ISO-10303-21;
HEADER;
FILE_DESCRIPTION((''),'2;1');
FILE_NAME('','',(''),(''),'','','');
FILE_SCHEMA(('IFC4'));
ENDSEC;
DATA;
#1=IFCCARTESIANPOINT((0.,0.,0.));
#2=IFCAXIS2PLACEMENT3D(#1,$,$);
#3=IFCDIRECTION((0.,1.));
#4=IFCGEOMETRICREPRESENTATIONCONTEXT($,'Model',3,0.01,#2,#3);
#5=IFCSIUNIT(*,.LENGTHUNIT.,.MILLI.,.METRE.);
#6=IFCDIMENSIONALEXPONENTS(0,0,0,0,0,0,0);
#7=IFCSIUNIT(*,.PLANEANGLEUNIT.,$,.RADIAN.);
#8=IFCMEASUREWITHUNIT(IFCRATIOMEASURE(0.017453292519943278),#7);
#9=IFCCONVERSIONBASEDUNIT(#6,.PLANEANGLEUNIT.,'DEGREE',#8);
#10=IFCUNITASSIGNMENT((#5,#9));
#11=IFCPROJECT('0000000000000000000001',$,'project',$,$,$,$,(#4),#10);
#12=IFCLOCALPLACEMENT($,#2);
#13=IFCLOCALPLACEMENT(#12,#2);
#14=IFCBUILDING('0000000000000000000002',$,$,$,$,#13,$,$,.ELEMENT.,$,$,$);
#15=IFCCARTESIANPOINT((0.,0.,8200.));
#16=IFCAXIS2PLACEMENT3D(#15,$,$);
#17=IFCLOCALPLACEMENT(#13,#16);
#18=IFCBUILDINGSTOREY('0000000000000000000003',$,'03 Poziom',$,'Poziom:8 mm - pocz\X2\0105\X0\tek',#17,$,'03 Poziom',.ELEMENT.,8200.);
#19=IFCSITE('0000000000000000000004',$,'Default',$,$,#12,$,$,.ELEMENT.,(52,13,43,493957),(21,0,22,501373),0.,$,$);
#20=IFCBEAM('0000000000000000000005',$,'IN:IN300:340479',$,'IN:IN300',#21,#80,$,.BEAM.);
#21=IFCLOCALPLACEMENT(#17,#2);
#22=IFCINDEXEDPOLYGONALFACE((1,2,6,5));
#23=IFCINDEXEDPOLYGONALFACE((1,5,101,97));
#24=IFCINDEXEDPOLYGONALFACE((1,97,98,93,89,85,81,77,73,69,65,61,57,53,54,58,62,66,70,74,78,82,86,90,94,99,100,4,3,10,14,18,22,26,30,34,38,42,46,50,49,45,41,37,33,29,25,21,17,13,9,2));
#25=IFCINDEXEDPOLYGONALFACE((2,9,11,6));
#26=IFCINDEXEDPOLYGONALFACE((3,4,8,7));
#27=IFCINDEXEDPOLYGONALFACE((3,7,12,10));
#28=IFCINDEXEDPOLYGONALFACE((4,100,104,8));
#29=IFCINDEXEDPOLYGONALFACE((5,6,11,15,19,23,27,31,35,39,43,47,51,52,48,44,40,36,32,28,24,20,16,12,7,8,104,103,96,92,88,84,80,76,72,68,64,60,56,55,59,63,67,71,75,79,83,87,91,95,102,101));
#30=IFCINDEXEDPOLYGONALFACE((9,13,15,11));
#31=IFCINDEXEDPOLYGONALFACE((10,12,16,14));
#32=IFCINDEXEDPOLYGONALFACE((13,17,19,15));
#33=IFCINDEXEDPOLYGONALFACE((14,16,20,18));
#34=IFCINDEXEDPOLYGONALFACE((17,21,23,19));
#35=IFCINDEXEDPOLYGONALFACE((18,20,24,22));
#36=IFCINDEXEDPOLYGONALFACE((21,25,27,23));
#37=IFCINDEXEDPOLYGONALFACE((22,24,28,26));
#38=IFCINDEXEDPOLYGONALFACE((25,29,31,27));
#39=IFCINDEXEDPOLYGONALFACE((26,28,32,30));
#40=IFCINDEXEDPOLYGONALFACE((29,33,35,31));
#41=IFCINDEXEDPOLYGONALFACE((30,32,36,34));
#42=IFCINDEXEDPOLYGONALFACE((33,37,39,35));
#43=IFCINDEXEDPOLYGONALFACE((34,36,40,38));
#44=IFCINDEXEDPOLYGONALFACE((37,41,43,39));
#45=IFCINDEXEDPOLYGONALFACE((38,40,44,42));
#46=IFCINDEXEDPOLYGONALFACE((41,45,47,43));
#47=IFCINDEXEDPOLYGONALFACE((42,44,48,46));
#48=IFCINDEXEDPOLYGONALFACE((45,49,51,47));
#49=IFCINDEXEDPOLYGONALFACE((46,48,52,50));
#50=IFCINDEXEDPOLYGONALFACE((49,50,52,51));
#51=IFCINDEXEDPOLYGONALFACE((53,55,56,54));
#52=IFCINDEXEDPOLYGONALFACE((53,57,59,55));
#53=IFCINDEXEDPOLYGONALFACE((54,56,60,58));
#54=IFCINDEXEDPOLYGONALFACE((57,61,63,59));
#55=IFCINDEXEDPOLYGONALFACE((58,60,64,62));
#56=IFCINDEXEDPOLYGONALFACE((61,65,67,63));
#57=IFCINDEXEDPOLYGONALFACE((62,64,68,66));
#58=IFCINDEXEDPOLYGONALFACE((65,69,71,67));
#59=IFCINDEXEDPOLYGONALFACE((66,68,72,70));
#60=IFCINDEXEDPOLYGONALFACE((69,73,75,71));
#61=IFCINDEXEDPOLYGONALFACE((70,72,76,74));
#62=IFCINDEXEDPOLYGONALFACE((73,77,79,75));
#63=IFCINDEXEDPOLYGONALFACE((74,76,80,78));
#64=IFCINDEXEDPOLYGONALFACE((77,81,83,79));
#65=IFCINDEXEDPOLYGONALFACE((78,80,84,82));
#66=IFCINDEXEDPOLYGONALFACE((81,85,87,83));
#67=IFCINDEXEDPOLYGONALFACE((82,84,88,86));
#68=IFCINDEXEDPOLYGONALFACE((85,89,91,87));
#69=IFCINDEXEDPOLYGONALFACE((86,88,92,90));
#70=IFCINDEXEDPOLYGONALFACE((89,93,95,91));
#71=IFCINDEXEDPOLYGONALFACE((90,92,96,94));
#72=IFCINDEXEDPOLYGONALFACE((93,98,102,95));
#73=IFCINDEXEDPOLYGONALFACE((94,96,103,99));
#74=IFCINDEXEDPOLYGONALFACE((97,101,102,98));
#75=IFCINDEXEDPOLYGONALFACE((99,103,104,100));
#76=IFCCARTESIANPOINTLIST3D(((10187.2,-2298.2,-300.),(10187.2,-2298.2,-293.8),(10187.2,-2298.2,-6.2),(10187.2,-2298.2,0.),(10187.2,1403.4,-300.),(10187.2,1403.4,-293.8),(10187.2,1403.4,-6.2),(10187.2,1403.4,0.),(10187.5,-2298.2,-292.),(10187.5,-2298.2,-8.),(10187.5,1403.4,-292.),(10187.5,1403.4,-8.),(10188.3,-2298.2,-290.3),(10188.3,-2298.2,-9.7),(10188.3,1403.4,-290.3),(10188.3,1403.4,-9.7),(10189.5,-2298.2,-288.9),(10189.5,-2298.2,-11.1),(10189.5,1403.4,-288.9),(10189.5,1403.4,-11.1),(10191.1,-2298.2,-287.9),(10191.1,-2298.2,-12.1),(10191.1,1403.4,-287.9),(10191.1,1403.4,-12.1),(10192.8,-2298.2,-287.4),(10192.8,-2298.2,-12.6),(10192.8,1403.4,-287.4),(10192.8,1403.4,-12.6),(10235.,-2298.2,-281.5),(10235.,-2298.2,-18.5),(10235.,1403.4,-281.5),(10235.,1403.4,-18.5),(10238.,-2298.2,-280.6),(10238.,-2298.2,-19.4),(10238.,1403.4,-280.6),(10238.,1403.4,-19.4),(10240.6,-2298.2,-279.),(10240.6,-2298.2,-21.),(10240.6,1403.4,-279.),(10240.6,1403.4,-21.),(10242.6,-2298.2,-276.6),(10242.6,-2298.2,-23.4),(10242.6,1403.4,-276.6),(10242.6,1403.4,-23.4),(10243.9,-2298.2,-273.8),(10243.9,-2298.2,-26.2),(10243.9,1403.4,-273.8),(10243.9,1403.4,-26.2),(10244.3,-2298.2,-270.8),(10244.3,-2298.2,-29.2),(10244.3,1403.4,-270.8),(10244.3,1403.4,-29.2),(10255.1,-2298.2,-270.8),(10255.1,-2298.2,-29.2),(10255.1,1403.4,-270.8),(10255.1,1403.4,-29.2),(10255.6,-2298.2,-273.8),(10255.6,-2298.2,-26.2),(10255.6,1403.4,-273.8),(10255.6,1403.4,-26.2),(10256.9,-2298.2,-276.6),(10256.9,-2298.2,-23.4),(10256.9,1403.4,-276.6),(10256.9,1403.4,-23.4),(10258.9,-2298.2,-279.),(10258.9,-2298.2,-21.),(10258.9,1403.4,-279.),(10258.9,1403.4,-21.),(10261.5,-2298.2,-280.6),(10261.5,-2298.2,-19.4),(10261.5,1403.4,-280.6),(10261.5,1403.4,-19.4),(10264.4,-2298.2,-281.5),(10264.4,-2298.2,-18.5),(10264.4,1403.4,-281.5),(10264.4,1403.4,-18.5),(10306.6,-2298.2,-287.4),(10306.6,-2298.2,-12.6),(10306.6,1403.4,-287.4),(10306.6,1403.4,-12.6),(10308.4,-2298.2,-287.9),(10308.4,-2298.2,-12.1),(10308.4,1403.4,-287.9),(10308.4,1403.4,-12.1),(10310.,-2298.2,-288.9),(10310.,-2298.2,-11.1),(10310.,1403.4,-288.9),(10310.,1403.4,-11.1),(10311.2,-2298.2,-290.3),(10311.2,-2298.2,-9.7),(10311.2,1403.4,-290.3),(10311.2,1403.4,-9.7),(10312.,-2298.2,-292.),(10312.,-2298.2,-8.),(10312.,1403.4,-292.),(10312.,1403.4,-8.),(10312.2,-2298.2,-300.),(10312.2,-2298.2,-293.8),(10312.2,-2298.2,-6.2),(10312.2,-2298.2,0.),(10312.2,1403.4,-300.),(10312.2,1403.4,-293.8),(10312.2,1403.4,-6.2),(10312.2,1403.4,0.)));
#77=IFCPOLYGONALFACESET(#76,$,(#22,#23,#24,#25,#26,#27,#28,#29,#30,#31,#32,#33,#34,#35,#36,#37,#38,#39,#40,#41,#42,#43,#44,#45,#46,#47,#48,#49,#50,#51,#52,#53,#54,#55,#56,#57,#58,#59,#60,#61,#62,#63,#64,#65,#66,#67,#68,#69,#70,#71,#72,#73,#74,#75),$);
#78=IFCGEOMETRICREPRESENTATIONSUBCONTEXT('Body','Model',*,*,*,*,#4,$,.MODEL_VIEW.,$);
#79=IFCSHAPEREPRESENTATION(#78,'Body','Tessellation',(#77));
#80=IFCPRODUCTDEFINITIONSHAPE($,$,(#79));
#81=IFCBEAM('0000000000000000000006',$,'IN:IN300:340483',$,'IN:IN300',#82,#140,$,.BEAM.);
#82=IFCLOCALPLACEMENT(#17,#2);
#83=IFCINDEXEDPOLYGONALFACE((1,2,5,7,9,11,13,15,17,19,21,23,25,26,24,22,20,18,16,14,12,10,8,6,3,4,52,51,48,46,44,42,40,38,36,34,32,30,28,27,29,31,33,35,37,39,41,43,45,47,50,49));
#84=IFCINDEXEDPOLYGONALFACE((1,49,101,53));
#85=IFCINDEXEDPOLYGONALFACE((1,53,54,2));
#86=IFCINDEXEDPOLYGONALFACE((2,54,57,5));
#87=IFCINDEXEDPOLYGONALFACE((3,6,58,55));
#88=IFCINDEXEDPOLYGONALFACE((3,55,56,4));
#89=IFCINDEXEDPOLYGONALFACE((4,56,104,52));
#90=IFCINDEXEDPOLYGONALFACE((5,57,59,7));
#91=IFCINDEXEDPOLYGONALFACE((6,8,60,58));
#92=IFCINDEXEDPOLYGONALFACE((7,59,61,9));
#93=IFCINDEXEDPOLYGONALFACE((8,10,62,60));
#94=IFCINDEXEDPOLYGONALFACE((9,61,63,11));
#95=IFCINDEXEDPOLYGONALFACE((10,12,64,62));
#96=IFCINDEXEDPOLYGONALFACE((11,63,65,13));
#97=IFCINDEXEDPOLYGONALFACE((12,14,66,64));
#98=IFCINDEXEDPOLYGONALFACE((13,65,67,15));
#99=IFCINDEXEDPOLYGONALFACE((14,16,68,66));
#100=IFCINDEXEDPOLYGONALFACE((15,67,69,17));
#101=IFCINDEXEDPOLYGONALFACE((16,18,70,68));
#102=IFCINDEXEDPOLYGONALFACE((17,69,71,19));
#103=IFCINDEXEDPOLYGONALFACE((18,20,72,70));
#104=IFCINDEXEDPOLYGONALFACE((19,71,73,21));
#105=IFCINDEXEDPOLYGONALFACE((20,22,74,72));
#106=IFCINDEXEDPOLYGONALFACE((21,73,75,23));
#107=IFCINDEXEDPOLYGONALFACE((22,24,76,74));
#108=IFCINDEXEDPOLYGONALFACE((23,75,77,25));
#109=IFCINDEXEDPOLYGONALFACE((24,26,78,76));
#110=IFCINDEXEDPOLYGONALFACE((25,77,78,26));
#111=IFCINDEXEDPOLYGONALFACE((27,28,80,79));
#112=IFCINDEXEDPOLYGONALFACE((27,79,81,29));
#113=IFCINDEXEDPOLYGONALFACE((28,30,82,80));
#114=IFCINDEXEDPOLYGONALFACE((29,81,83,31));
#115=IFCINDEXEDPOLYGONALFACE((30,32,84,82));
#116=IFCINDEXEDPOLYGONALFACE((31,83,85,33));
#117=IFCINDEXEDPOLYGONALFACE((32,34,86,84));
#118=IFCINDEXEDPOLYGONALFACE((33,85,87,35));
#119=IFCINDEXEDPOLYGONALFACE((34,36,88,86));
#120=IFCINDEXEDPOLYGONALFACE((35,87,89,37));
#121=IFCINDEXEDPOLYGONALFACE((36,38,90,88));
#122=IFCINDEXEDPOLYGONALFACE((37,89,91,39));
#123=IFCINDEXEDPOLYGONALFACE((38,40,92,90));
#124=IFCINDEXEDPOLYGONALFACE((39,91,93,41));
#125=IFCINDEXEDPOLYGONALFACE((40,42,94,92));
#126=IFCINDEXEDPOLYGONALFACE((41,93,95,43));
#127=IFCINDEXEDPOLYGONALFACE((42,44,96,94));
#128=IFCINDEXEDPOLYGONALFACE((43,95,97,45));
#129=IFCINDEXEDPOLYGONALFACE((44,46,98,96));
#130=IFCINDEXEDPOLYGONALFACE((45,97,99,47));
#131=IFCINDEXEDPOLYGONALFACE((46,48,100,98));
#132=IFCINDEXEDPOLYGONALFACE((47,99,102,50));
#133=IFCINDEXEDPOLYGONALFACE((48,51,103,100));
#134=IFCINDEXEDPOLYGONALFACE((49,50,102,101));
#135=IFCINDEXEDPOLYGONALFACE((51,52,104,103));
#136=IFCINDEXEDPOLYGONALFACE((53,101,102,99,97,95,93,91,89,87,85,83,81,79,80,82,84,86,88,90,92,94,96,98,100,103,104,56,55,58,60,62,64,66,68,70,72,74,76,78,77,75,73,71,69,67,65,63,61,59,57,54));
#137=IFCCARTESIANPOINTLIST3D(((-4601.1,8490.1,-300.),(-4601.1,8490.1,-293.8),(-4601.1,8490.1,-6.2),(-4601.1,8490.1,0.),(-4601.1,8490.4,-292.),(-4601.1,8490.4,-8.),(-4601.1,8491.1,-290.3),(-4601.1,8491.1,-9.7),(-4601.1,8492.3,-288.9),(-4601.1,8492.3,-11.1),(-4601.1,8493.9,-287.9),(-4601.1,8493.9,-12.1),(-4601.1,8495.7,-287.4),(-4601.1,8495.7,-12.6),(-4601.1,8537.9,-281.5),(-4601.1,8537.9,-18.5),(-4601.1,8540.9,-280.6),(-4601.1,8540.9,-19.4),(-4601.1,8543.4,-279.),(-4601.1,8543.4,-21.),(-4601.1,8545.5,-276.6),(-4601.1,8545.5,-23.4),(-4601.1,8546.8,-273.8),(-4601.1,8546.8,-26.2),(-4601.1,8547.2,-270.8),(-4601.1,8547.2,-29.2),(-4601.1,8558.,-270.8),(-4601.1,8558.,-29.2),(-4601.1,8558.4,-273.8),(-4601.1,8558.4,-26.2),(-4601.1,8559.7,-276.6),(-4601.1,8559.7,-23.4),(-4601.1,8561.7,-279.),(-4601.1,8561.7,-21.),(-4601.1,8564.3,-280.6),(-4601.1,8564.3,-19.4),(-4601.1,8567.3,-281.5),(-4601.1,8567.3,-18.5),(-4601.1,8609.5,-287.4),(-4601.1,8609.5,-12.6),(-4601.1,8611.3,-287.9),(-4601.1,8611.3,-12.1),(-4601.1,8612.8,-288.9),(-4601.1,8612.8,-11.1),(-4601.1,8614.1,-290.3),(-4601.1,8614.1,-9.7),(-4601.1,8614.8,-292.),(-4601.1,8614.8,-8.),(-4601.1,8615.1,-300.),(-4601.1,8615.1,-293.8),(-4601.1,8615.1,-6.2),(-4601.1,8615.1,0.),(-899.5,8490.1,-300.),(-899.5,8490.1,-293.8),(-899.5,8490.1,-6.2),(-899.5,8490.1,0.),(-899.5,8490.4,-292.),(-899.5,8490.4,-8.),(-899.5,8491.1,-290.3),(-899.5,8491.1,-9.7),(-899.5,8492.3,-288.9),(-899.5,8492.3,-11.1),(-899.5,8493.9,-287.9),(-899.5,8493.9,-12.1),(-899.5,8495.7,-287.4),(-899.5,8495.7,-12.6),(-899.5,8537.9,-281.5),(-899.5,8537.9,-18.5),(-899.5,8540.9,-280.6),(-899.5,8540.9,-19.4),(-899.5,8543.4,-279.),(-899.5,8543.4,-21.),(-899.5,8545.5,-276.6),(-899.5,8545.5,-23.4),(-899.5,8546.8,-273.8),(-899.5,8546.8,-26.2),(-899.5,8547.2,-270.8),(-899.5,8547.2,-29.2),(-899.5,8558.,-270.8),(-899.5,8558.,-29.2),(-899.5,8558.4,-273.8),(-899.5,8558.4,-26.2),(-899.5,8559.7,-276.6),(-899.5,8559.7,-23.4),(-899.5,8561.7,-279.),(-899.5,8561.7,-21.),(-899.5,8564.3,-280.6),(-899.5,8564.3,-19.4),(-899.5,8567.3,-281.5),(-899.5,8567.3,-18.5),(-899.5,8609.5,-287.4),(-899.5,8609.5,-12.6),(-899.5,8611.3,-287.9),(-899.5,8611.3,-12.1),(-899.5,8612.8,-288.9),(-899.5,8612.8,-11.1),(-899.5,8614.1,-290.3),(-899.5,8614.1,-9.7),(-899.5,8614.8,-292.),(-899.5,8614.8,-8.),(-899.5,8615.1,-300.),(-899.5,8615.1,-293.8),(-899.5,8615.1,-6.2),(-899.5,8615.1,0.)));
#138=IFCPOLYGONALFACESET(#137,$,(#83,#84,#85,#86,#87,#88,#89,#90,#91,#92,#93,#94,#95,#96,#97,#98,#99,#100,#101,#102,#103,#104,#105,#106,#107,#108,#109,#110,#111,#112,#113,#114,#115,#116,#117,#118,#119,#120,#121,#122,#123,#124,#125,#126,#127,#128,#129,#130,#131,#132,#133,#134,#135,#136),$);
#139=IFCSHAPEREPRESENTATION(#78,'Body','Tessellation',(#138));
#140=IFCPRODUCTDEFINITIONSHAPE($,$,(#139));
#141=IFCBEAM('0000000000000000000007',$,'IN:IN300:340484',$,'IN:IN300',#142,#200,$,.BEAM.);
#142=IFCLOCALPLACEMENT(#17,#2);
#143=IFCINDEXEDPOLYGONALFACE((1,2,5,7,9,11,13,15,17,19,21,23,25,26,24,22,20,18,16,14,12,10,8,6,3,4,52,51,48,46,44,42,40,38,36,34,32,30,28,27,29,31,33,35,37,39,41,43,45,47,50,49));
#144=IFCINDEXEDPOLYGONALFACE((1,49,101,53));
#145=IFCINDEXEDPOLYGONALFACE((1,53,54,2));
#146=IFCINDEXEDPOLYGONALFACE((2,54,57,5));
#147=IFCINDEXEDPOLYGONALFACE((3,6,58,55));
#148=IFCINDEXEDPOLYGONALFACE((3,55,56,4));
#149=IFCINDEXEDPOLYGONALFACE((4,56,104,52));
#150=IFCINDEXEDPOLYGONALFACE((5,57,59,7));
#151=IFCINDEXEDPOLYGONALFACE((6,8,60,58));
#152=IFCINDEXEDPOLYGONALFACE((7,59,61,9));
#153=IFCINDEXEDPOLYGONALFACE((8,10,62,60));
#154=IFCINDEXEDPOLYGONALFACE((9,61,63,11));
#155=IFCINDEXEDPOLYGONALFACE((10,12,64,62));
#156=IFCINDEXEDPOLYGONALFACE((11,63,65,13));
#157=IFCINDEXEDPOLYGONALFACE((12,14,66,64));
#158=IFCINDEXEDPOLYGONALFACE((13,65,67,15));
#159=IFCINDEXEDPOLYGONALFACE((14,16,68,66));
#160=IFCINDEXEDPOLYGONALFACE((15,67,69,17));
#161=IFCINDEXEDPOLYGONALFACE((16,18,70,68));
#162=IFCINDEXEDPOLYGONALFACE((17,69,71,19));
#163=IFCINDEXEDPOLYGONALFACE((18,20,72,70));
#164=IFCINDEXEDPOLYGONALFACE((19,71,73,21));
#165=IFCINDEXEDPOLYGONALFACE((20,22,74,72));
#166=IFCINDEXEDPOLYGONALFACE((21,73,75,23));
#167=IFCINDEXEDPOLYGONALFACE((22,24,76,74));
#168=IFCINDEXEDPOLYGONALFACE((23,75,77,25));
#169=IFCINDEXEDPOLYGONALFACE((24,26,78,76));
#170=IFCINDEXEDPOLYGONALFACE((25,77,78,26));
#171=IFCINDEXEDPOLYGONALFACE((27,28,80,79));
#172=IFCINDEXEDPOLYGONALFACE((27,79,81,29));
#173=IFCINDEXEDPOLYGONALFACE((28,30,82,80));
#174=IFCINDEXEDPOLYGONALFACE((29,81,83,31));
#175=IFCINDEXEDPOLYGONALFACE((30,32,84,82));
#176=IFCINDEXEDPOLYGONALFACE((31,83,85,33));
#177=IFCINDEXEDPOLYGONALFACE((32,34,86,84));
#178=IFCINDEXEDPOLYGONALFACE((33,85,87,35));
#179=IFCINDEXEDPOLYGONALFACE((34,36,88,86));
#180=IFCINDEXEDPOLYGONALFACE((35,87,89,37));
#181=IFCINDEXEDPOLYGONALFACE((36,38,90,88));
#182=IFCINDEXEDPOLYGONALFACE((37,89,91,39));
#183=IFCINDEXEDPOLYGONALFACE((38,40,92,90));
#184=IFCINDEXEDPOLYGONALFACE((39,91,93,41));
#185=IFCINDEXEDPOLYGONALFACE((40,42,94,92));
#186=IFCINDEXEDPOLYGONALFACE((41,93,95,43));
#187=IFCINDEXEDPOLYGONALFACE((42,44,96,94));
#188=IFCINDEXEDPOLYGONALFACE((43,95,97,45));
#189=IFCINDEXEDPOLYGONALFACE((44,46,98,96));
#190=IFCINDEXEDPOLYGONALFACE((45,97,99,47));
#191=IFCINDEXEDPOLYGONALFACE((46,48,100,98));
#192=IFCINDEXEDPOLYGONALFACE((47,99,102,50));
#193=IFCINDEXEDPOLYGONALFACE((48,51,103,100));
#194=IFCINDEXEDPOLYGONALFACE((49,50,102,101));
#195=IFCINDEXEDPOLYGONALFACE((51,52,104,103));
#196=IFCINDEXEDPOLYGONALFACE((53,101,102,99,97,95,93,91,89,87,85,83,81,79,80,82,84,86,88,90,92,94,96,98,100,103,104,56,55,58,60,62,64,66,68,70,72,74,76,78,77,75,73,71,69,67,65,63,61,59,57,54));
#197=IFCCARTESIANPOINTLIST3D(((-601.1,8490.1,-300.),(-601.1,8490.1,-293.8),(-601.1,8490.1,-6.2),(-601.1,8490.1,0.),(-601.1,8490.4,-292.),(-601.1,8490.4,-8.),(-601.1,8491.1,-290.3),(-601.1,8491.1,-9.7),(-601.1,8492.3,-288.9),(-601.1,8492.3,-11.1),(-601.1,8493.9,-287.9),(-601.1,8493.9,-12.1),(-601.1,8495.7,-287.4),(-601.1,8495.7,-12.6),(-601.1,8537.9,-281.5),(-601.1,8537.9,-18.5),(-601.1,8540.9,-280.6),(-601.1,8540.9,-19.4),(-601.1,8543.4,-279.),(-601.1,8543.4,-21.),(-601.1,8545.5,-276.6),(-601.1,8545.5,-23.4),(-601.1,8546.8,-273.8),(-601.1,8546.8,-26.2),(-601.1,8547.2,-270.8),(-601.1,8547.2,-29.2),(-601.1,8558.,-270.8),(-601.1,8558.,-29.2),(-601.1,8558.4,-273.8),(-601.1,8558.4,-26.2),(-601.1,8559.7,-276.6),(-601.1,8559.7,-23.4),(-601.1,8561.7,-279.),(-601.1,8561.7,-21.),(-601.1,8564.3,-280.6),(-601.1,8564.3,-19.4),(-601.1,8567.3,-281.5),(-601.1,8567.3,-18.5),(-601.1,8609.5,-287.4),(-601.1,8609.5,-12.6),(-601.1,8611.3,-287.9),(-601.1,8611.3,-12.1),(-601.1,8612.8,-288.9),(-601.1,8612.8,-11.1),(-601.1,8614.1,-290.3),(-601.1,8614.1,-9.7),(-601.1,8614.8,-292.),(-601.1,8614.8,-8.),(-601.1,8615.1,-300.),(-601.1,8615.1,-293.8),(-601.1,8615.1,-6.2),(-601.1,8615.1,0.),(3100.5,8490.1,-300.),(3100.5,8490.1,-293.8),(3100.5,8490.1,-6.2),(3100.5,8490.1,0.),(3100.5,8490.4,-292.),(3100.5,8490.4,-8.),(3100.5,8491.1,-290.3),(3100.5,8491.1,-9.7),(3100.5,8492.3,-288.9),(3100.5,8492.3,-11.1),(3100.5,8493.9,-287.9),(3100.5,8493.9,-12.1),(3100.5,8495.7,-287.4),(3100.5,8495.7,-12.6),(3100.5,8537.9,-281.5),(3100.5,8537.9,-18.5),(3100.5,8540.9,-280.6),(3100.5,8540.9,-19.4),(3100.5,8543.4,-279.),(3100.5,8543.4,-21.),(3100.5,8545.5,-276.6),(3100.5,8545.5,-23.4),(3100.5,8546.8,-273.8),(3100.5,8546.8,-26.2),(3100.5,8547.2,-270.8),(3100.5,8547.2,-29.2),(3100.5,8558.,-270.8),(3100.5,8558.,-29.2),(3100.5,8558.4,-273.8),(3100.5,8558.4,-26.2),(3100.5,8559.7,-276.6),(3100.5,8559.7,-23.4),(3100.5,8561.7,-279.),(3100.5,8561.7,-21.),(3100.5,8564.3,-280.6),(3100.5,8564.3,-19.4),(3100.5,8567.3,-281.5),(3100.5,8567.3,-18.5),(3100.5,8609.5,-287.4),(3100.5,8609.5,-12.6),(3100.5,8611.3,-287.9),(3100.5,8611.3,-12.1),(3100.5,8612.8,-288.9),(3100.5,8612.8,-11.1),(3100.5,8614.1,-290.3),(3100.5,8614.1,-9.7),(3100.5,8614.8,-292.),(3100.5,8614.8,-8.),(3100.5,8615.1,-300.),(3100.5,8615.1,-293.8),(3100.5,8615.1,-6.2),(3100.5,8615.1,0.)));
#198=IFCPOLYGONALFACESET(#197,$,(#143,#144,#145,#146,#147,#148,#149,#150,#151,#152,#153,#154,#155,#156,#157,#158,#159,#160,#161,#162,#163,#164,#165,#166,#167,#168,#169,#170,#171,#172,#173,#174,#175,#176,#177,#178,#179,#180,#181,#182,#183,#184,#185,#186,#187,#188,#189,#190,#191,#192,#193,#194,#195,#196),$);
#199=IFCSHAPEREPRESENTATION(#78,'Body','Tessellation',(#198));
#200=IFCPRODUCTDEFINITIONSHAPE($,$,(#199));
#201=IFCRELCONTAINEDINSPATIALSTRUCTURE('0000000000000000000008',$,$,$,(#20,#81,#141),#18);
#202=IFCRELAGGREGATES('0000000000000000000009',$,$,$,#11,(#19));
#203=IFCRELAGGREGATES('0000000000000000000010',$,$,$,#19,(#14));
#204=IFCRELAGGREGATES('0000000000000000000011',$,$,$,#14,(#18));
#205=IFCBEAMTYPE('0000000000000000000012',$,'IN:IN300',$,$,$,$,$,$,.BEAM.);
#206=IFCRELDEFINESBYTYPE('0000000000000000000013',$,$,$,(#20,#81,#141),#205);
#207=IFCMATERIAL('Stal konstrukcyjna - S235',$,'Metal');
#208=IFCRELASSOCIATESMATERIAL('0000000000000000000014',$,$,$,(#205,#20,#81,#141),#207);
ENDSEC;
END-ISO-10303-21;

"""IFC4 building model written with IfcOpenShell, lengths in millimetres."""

from ifc_helpers import new_model, entity, si_unit, converted_unit, direction, frame, origin, place, context, subcontext, project, spatial, line, arc, indexed_curve, outline, extrude, source, transform, mapped, material, type_object, type_shapes, element, save


model = new_model("IFC4")

# Units and contexts
model_context = context("Model", 3, precision=0.01, world=origin(), true_north=direction((0.0, 1.0)))
body_context = subcontext(model_context, "Body", "Model", "MODEL_VIEW")
ifc_project = project(units=[si_unit("LENGTHUNIT", "METRE", prefix="MILLI"), converted_unit("PLANEANGLEUNIT", "DEGREE", entity("IfcRatioMeasure", 0.017453292519943278), si_unit("PLANEANGLEUNIT", "RADIAN"), dimensions=[0, 0, 0, 0, 0, 0, 0])], contexts=[model_context])

# Site, building, storey
site_placement = place(None, origin())
site = spatial("IfcSite", under=ifc_project, at=site_placement, Name="Default", CompositionType="ELEMENT", RefLatitude=(52, 13, 43, 493957), RefLongitude=(21, 0, 22, 501373), RefElevation=0.0)
building_placement = place(site_placement, origin())
building = spatial("IfcBuilding", under=site, at=building_placement, CompositionType="ELEMENT")
storey_placement = place(building_placement, frame((0.0, 0.0, 8200.0)))
storey = spatial("IfcBuildingStorey", under=building, at=storey_placement, Name="03 Poziom", ObjectType="Poziom:8 mm - początek", LongName="03 Poziom", CompositionType="ELEMENT", Elevation=8200.0)

# Shared definitions
ifc_material_1 = material(Name="Stal konstrukcyjna - S235", Category="Metal")

# Beams
beam_type_1 = type_object("IfcBeamType", Name="IN:IN300", PredefinedType="BEAM", material=ifc_material_1)
shared_shape_1 = source(origin(), body_context, "Body", "SweptSolid", [
    extrude(outline(indexed_curve([(143.8, -62.5), (150.0, -62.5), (150.0, 62.5), (143.8, 62.5), (139.6, 60.9), (137.4, 56.9), (131.5, 14.7), (127.9, 8.1), (120.8, 5.4), (-120.8, 5.4), (-127.9, 8.1), (-131.5, 14.7), (-137.4, 56.9), (-139.6, 60.9), (-143.8, 62.5), (-150.0, 62.5), (-150.0, -62.5), (-143.8, -62.5), (-139.6, -60.9), (-137.4, -56.9), (-131.5, -14.7), (-127.9, -8.1), (-120.8, -5.4), (120.8, -5.4), (127.9, -8.1), (131.5, -14.7), (137.4, -56.9), (139.6, -60.9)], segments=[line(1, 2, 3, 4), arc(4, 5, 6), line(6, 7), arc(7, 8, 9), line(9, 10), arc(10, 11, 12), line(12, 13), arc(13, 14, 15), line(15, 16, 17, 18), arc(18, 19, 20), line(20, 21), arc(21, 22, 23), line(23, 24), arc(24, 25, 26), line(26, 27), arc(27, 28, 1)], self_intersect=False)), frame((-1850.8, 0.0, 0.0), z_axis=(1.0, 0.0, 0.0), x_axis=(0.0, 0.0, -1.0)), (0.0, 0.0, 1.0), 3701.6),
])
type_shapes(beam_type_1, [shared_shape_1])
for number, where, z_axis, x_axis, name in (
    (1, (10249.7, -447.4, -150.0), (0.0, 0.0, 1.0), (0.0, -1.0, 0.0), "IN:IN300:340479"),
):
    element("IfcBeam", number, at=place(storey_placement, frame(where, z_axis=z_axis, x_axis=x_axis)), inside=storey, type_object=beam_type_1, material=ifc_material_1, Name=name, ObjectType="IN:IN300", PredefinedType="BEAM", context=body_context, shape_type="MappedRepresentation", body=[
        mapped(shared_shape_1, transform((0.0, 0.0, 0.0), scale=1.0)),
    ])
for number, where, name in (
    (2, (-2750.3, 8552.6, -150.0), "IN:IN300:340483"),
    (3, (1249.7, 8552.6, -150.0), "IN:IN300:340484"),
):
    element("IfcBeam", number, at=place(storey_placement, frame(where)), inside=storey, type_object=beam_type_1, material=ifc_material_1, Name=name, ObjectType="IN:IN300", PredefinedType="BEAM", context=body_context, shape_type="MappedRepresentation", body=[
        mapped(shared_shape_1, transform((0.0, 0.0, 0.0), scale=1.0)),
    ])

save(model, "model.ifc")
